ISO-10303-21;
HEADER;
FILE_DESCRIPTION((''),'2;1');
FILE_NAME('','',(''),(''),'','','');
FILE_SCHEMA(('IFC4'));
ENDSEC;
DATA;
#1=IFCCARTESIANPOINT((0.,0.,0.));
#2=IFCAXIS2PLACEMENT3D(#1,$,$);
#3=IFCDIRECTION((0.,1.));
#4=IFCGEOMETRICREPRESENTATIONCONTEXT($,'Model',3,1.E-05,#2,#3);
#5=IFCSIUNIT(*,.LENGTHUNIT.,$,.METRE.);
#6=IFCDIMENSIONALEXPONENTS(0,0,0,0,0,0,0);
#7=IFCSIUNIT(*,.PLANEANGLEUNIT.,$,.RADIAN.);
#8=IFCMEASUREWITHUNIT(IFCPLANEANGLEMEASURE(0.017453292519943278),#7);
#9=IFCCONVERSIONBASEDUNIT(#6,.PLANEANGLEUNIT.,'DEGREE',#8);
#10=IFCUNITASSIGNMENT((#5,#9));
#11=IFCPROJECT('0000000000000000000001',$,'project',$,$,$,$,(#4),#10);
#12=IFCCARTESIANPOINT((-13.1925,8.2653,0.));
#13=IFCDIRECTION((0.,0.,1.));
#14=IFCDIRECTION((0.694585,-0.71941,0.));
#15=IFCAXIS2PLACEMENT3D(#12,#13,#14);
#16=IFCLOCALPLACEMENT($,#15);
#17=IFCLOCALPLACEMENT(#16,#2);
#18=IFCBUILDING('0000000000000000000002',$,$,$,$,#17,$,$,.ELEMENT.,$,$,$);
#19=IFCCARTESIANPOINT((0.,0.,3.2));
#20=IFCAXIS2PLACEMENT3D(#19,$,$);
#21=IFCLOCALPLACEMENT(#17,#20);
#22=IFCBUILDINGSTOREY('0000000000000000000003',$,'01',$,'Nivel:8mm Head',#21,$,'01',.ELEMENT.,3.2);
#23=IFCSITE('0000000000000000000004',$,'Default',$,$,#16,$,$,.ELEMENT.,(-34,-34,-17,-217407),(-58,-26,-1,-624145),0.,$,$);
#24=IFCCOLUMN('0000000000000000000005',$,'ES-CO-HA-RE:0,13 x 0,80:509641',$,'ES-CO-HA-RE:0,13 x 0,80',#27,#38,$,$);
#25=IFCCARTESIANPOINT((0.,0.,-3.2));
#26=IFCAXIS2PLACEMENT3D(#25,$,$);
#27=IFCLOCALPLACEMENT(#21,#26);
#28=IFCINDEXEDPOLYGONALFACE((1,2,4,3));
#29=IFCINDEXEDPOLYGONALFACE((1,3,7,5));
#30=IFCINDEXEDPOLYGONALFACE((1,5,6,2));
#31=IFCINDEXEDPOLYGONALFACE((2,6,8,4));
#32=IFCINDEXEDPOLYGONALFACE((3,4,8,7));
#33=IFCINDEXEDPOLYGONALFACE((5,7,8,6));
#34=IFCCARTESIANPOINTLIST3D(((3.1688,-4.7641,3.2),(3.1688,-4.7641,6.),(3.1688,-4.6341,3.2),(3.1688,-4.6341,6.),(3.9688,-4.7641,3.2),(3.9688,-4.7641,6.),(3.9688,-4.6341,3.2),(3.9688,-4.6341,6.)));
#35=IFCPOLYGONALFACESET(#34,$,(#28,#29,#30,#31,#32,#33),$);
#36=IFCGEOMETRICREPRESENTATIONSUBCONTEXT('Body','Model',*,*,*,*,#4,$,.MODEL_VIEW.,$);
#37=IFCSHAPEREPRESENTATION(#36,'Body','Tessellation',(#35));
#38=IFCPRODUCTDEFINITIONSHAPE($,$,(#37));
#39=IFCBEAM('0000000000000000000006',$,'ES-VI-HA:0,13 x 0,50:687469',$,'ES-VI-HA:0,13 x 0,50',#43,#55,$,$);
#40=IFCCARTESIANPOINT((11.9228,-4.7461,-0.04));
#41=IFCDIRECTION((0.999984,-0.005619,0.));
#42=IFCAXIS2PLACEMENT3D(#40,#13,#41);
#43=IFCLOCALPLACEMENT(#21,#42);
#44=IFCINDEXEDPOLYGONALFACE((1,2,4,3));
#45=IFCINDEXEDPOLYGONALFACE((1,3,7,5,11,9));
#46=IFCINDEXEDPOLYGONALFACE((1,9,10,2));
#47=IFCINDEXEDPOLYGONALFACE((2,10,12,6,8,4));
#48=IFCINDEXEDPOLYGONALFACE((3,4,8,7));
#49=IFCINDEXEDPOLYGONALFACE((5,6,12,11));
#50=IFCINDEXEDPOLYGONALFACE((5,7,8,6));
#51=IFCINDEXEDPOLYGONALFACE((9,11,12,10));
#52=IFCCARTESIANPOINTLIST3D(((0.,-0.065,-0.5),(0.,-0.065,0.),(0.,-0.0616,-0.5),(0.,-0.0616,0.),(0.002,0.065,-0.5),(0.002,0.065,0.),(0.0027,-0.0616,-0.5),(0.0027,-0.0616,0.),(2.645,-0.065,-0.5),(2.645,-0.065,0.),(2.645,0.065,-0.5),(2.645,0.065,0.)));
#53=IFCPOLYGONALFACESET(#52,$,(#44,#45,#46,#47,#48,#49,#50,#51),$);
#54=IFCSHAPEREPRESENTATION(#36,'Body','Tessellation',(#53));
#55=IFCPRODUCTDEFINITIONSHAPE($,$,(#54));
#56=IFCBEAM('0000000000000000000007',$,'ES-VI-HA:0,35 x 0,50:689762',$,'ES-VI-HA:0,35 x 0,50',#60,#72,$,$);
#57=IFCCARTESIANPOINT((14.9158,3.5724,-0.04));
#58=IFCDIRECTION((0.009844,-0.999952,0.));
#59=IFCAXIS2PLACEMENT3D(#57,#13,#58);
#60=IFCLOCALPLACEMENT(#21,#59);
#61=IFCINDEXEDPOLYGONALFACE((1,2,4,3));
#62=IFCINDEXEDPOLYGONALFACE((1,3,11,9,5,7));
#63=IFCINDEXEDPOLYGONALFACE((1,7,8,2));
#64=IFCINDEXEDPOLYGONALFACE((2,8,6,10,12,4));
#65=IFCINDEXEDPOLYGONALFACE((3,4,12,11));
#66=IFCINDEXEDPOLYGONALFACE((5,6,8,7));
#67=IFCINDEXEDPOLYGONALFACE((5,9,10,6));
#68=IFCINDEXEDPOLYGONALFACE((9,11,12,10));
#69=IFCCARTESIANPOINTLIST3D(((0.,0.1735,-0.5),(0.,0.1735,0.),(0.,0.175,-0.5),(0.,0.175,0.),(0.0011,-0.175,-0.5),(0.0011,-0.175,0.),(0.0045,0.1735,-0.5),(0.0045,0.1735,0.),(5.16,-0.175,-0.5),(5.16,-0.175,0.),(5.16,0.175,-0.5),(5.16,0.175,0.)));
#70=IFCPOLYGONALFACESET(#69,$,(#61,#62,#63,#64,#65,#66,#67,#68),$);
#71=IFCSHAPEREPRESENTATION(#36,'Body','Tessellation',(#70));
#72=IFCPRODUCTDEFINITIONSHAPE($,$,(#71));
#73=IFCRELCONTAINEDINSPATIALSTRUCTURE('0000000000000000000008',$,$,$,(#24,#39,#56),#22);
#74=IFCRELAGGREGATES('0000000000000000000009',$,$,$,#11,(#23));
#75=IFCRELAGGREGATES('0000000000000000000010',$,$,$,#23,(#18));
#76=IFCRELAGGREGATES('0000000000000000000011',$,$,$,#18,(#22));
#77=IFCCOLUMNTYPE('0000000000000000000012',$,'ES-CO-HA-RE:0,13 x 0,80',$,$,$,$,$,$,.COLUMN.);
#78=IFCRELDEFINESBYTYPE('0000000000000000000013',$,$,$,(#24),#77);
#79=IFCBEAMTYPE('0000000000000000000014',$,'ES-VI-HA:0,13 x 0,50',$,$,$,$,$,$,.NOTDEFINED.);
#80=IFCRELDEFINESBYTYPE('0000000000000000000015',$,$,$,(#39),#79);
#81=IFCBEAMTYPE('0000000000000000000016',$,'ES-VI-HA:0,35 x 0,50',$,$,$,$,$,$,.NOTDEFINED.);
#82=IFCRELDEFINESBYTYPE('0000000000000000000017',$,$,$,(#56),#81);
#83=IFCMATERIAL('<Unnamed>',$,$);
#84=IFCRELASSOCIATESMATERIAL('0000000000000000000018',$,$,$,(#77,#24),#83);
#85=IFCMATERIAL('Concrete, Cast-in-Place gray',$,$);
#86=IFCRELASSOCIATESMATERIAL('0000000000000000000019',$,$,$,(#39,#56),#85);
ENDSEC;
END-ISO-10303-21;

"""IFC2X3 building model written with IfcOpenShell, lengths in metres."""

from ifc_helpers import new_model, entity, si_unit, converted_unit, direction, frame, frame_2d, origin, origin_2d_with_axis, place, context, subcontext, project, spatial, polyline, rectangle, extrude, clip, bounded_halfspace, source, transform, mapped, material, type_object, type_shapes, element, save


model = new_model("IFC2X3")

# Units and contexts
model_context = context("Model", 3, precision=1e-05, world=origin(), true_north=direction((0.0, 1.0)))
body_context = subcontext(model_context, "Body", "Model", "MODEL_VIEW")
ifc_project = project(units=[si_unit("LENGTHUNIT", "METRE"), converted_unit("PLANEANGLEUNIT", "DEGREE", entity("IfcPlaneAngleMeasure", 0.017453292519943278), si_unit("PLANEANGLEUNIT", "RADIAN"), dimensions=[0, 0, 0, 0, 0, 0, 0])], contexts=[model_context])

# Site, building, storey
site_placement = place(None, frame((-13.1925, 8.2653, 0.0), z_axis=(0.0, 0.0, 1.0), x_axis=(0.694585, -0.71941, 0.0)))
site = spatial("IfcSite", under=ifc_project, at=site_placement, Name="Default", CompositionType="ELEMENT", RefLatitude=(-34, -34, -17, -217407), RefLongitude=(-58, -26, -1, -624145), RefElevation=0.0)
building_placement = place(site_placement, origin())
building = spatial("IfcBuilding", under=site, at=building_placement, CompositionType="ELEMENT")
storey_placement = place(building_placement, frame((0.0, 0.0, 3.2)))
storey = spatial("IfcBuildingStorey", under=building, at=storey_placement, Name="01", ObjectType="Nivel:8mm Head", LongName="01", CompositionType="ELEMENT", Elevation=3.2)

# Column
ifc_material_1 = material(Name="<Unnamed>")
column_type_1 = type_object("IfcColumnType", Name="ES-CO-HA-RE:0,13 x 0,80", PredefinedType="COLUMN", material=ifc_material_1)
shared_shape_1 = source(origin(), body_context, "Body", "SweptSolid", [
    extrude(rectangle(XDim=0.8, YDim=0.13, at=frame_2d((0.0, 0.0), x_axis=(1.0, 0.0))), frame((3.5688, -4.6991, 3.2), z_axis=(0.0, 0.0, 1.0), x_axis=(-1.0, 0.0, 0.0)), (0.0, 0.0, 1.0), 2.8),
])
type_shapes(column_type_1, [shared_shape_1])
column_1_placement = place(storey_placement, frame((0.0, 0.0, -3.2)))
element("IfcColumn", 1, at=column_1_placement, inside=storey, type_object=column_type_1, material=ifc_material_1, Name="ES-CO-HA-RE:0,13 x 0,80:509641", ObjectType="ES-CO-HA-RE:0,13 x 0,80", context=body_context, shape_type="MappedRepresentation", body=[
    mapped(shared_shape_1, transform((0.0, 0.0, 0.0), scale=1.0)),
])

# Beams
ifc_material_2 = material(Name="Concrete, Cast-in-Place gray")
beam_type_1 = type_object("IfcBeamType", Name="ES-VI-HA:0,13 x 0,50", PredefinedType="NOTDEFINED")
beam_1_placement = place(storey_placement, frame((11.9228, -4.7461, -0.04), z_axis=(0.0, 0.0, 1.0), x_axis=(0.999984, -0.005619, 0.0)))
element("IfcBeam", 2, at=beam_1_placement, inside=storey, type_object=beam_type_1, material=ifc_material_2, Name="ES-VI-HA:0,13 x 0,50:687469", ObjectType="ES-VI-HA:0,13 x 0,50", context=body_context, shape_type="SweptSolid", body=[
    clip(clip(extrude(rectangle(XDim=0.5, YDim=0.13, at=frame_2d((0.0, 0.0), x_axis=(1.0, 0.0))), frame((0.0, 0.0, -0.25), z_axis=(1.0, 0.0, 0.0), x_axis=(0.0, 0.0, -1.0)), (0.0, 0.0, 1.0), 2.645), bounded_halfspace(frame((0.0027, -0.0616, 0.04), z_axis=(-0.999984, -0.005619, 0.0), x_axis=(0.0, 0.0, -1.0)), False, frame((0.0, 0.0, -0.25), z_axis=(1.0, 0.0, 0.0), x_axis=(0.0, 0.0, -1.0)), polyline([(0.25, -0.0616), (-0.25, -0.0616), (-0.25, 0.065), (0.25, 0.065), (0.25, -0.0616)]))), bounded_halfspace(frame((-0.6473, -0.0652, 0.04), z_axis=(-0.005619, 0.999984, 0.0), x_axis=(0.0, 0.0, -1.0)), False, frame((0.0, 0.0, -0.25), z_axis=(1.0, 0.0, 0.0), x_axis=(0.0, 0.0, -1.0)), polyline([(-0.25, -0.0616), (0.25, -0.0616), (0.25, -0.0616), (-0.25, -0.0616), (-0.25, -0.0616)]))),
])
beam_type_2 = type_object("IfcBeamType", Name="ES-VI-HA:0,35 x 0,50", PredefinedType="NOTDEFINED")
beam_2_placement = place(storey_placement, frame((14.9158, 3.5724, -0.04), z_axis=(0.0, 0.0, 1.0), x_axis=(0.009844, -0.999952, 0.0)))
element("IfcBeam", 3, at=beam_2_placement, inside=storey, type_object=beam_type_2, material=ifc_material_2, Name="ES-VI-HA:0,35 x 0,50:689762", ObjectType="ES-VI-HA:0,35 x 0,50", context=body_context, shape_type="SweptSolid", body=[
    clip(clip(extrude(rectangle(XDim=0.5, YDim=0.35, at=origin_2d_with_axis()), frame((0.0, 0.0, -0.25), z_axis=(1.0, 0.0, 0.0), x_axis=(0.0, 0.0, -1.0)), (0.0, 0.0, 1.0), 5.16), bounded_halfspace(frame((0.0045, 0.1735, 0.04), z_axis=(-0.009844, -0.999952, 0.0), x_axis=(0.0, 0.0, -1.0)), False, frame((0.0, 0.0, -0.25), z_axis=(1.0, 0.0, 0.0), x_axis=(0.0, 0.0, -1.0)), polyline([(0.25, 0.1735), (-0.25, 0.1735), (-0.25, 0.1735), (0.25, 0.1735), (0.25, 0.1735)]))), bounded_halfspace(frame((-0.0053, -0.8265, 0.04), z_axis=(-0.999952, 0.009844, 0.0), x_axis=(0.0, 0.0, -1.0)), False, frame((0.0, 0.0, -0.25), z_axis=(1.0, 0.0, 0.0), x_axis=(0.0, 0.0, -1.0)), polyline([(-0.25, 0.1735), (0.25, 0.1735), (0.25, -0.175), (-0.25, -0.175), (-0.25, 0.1735)]))),
])

save(model, "model.ifc")
